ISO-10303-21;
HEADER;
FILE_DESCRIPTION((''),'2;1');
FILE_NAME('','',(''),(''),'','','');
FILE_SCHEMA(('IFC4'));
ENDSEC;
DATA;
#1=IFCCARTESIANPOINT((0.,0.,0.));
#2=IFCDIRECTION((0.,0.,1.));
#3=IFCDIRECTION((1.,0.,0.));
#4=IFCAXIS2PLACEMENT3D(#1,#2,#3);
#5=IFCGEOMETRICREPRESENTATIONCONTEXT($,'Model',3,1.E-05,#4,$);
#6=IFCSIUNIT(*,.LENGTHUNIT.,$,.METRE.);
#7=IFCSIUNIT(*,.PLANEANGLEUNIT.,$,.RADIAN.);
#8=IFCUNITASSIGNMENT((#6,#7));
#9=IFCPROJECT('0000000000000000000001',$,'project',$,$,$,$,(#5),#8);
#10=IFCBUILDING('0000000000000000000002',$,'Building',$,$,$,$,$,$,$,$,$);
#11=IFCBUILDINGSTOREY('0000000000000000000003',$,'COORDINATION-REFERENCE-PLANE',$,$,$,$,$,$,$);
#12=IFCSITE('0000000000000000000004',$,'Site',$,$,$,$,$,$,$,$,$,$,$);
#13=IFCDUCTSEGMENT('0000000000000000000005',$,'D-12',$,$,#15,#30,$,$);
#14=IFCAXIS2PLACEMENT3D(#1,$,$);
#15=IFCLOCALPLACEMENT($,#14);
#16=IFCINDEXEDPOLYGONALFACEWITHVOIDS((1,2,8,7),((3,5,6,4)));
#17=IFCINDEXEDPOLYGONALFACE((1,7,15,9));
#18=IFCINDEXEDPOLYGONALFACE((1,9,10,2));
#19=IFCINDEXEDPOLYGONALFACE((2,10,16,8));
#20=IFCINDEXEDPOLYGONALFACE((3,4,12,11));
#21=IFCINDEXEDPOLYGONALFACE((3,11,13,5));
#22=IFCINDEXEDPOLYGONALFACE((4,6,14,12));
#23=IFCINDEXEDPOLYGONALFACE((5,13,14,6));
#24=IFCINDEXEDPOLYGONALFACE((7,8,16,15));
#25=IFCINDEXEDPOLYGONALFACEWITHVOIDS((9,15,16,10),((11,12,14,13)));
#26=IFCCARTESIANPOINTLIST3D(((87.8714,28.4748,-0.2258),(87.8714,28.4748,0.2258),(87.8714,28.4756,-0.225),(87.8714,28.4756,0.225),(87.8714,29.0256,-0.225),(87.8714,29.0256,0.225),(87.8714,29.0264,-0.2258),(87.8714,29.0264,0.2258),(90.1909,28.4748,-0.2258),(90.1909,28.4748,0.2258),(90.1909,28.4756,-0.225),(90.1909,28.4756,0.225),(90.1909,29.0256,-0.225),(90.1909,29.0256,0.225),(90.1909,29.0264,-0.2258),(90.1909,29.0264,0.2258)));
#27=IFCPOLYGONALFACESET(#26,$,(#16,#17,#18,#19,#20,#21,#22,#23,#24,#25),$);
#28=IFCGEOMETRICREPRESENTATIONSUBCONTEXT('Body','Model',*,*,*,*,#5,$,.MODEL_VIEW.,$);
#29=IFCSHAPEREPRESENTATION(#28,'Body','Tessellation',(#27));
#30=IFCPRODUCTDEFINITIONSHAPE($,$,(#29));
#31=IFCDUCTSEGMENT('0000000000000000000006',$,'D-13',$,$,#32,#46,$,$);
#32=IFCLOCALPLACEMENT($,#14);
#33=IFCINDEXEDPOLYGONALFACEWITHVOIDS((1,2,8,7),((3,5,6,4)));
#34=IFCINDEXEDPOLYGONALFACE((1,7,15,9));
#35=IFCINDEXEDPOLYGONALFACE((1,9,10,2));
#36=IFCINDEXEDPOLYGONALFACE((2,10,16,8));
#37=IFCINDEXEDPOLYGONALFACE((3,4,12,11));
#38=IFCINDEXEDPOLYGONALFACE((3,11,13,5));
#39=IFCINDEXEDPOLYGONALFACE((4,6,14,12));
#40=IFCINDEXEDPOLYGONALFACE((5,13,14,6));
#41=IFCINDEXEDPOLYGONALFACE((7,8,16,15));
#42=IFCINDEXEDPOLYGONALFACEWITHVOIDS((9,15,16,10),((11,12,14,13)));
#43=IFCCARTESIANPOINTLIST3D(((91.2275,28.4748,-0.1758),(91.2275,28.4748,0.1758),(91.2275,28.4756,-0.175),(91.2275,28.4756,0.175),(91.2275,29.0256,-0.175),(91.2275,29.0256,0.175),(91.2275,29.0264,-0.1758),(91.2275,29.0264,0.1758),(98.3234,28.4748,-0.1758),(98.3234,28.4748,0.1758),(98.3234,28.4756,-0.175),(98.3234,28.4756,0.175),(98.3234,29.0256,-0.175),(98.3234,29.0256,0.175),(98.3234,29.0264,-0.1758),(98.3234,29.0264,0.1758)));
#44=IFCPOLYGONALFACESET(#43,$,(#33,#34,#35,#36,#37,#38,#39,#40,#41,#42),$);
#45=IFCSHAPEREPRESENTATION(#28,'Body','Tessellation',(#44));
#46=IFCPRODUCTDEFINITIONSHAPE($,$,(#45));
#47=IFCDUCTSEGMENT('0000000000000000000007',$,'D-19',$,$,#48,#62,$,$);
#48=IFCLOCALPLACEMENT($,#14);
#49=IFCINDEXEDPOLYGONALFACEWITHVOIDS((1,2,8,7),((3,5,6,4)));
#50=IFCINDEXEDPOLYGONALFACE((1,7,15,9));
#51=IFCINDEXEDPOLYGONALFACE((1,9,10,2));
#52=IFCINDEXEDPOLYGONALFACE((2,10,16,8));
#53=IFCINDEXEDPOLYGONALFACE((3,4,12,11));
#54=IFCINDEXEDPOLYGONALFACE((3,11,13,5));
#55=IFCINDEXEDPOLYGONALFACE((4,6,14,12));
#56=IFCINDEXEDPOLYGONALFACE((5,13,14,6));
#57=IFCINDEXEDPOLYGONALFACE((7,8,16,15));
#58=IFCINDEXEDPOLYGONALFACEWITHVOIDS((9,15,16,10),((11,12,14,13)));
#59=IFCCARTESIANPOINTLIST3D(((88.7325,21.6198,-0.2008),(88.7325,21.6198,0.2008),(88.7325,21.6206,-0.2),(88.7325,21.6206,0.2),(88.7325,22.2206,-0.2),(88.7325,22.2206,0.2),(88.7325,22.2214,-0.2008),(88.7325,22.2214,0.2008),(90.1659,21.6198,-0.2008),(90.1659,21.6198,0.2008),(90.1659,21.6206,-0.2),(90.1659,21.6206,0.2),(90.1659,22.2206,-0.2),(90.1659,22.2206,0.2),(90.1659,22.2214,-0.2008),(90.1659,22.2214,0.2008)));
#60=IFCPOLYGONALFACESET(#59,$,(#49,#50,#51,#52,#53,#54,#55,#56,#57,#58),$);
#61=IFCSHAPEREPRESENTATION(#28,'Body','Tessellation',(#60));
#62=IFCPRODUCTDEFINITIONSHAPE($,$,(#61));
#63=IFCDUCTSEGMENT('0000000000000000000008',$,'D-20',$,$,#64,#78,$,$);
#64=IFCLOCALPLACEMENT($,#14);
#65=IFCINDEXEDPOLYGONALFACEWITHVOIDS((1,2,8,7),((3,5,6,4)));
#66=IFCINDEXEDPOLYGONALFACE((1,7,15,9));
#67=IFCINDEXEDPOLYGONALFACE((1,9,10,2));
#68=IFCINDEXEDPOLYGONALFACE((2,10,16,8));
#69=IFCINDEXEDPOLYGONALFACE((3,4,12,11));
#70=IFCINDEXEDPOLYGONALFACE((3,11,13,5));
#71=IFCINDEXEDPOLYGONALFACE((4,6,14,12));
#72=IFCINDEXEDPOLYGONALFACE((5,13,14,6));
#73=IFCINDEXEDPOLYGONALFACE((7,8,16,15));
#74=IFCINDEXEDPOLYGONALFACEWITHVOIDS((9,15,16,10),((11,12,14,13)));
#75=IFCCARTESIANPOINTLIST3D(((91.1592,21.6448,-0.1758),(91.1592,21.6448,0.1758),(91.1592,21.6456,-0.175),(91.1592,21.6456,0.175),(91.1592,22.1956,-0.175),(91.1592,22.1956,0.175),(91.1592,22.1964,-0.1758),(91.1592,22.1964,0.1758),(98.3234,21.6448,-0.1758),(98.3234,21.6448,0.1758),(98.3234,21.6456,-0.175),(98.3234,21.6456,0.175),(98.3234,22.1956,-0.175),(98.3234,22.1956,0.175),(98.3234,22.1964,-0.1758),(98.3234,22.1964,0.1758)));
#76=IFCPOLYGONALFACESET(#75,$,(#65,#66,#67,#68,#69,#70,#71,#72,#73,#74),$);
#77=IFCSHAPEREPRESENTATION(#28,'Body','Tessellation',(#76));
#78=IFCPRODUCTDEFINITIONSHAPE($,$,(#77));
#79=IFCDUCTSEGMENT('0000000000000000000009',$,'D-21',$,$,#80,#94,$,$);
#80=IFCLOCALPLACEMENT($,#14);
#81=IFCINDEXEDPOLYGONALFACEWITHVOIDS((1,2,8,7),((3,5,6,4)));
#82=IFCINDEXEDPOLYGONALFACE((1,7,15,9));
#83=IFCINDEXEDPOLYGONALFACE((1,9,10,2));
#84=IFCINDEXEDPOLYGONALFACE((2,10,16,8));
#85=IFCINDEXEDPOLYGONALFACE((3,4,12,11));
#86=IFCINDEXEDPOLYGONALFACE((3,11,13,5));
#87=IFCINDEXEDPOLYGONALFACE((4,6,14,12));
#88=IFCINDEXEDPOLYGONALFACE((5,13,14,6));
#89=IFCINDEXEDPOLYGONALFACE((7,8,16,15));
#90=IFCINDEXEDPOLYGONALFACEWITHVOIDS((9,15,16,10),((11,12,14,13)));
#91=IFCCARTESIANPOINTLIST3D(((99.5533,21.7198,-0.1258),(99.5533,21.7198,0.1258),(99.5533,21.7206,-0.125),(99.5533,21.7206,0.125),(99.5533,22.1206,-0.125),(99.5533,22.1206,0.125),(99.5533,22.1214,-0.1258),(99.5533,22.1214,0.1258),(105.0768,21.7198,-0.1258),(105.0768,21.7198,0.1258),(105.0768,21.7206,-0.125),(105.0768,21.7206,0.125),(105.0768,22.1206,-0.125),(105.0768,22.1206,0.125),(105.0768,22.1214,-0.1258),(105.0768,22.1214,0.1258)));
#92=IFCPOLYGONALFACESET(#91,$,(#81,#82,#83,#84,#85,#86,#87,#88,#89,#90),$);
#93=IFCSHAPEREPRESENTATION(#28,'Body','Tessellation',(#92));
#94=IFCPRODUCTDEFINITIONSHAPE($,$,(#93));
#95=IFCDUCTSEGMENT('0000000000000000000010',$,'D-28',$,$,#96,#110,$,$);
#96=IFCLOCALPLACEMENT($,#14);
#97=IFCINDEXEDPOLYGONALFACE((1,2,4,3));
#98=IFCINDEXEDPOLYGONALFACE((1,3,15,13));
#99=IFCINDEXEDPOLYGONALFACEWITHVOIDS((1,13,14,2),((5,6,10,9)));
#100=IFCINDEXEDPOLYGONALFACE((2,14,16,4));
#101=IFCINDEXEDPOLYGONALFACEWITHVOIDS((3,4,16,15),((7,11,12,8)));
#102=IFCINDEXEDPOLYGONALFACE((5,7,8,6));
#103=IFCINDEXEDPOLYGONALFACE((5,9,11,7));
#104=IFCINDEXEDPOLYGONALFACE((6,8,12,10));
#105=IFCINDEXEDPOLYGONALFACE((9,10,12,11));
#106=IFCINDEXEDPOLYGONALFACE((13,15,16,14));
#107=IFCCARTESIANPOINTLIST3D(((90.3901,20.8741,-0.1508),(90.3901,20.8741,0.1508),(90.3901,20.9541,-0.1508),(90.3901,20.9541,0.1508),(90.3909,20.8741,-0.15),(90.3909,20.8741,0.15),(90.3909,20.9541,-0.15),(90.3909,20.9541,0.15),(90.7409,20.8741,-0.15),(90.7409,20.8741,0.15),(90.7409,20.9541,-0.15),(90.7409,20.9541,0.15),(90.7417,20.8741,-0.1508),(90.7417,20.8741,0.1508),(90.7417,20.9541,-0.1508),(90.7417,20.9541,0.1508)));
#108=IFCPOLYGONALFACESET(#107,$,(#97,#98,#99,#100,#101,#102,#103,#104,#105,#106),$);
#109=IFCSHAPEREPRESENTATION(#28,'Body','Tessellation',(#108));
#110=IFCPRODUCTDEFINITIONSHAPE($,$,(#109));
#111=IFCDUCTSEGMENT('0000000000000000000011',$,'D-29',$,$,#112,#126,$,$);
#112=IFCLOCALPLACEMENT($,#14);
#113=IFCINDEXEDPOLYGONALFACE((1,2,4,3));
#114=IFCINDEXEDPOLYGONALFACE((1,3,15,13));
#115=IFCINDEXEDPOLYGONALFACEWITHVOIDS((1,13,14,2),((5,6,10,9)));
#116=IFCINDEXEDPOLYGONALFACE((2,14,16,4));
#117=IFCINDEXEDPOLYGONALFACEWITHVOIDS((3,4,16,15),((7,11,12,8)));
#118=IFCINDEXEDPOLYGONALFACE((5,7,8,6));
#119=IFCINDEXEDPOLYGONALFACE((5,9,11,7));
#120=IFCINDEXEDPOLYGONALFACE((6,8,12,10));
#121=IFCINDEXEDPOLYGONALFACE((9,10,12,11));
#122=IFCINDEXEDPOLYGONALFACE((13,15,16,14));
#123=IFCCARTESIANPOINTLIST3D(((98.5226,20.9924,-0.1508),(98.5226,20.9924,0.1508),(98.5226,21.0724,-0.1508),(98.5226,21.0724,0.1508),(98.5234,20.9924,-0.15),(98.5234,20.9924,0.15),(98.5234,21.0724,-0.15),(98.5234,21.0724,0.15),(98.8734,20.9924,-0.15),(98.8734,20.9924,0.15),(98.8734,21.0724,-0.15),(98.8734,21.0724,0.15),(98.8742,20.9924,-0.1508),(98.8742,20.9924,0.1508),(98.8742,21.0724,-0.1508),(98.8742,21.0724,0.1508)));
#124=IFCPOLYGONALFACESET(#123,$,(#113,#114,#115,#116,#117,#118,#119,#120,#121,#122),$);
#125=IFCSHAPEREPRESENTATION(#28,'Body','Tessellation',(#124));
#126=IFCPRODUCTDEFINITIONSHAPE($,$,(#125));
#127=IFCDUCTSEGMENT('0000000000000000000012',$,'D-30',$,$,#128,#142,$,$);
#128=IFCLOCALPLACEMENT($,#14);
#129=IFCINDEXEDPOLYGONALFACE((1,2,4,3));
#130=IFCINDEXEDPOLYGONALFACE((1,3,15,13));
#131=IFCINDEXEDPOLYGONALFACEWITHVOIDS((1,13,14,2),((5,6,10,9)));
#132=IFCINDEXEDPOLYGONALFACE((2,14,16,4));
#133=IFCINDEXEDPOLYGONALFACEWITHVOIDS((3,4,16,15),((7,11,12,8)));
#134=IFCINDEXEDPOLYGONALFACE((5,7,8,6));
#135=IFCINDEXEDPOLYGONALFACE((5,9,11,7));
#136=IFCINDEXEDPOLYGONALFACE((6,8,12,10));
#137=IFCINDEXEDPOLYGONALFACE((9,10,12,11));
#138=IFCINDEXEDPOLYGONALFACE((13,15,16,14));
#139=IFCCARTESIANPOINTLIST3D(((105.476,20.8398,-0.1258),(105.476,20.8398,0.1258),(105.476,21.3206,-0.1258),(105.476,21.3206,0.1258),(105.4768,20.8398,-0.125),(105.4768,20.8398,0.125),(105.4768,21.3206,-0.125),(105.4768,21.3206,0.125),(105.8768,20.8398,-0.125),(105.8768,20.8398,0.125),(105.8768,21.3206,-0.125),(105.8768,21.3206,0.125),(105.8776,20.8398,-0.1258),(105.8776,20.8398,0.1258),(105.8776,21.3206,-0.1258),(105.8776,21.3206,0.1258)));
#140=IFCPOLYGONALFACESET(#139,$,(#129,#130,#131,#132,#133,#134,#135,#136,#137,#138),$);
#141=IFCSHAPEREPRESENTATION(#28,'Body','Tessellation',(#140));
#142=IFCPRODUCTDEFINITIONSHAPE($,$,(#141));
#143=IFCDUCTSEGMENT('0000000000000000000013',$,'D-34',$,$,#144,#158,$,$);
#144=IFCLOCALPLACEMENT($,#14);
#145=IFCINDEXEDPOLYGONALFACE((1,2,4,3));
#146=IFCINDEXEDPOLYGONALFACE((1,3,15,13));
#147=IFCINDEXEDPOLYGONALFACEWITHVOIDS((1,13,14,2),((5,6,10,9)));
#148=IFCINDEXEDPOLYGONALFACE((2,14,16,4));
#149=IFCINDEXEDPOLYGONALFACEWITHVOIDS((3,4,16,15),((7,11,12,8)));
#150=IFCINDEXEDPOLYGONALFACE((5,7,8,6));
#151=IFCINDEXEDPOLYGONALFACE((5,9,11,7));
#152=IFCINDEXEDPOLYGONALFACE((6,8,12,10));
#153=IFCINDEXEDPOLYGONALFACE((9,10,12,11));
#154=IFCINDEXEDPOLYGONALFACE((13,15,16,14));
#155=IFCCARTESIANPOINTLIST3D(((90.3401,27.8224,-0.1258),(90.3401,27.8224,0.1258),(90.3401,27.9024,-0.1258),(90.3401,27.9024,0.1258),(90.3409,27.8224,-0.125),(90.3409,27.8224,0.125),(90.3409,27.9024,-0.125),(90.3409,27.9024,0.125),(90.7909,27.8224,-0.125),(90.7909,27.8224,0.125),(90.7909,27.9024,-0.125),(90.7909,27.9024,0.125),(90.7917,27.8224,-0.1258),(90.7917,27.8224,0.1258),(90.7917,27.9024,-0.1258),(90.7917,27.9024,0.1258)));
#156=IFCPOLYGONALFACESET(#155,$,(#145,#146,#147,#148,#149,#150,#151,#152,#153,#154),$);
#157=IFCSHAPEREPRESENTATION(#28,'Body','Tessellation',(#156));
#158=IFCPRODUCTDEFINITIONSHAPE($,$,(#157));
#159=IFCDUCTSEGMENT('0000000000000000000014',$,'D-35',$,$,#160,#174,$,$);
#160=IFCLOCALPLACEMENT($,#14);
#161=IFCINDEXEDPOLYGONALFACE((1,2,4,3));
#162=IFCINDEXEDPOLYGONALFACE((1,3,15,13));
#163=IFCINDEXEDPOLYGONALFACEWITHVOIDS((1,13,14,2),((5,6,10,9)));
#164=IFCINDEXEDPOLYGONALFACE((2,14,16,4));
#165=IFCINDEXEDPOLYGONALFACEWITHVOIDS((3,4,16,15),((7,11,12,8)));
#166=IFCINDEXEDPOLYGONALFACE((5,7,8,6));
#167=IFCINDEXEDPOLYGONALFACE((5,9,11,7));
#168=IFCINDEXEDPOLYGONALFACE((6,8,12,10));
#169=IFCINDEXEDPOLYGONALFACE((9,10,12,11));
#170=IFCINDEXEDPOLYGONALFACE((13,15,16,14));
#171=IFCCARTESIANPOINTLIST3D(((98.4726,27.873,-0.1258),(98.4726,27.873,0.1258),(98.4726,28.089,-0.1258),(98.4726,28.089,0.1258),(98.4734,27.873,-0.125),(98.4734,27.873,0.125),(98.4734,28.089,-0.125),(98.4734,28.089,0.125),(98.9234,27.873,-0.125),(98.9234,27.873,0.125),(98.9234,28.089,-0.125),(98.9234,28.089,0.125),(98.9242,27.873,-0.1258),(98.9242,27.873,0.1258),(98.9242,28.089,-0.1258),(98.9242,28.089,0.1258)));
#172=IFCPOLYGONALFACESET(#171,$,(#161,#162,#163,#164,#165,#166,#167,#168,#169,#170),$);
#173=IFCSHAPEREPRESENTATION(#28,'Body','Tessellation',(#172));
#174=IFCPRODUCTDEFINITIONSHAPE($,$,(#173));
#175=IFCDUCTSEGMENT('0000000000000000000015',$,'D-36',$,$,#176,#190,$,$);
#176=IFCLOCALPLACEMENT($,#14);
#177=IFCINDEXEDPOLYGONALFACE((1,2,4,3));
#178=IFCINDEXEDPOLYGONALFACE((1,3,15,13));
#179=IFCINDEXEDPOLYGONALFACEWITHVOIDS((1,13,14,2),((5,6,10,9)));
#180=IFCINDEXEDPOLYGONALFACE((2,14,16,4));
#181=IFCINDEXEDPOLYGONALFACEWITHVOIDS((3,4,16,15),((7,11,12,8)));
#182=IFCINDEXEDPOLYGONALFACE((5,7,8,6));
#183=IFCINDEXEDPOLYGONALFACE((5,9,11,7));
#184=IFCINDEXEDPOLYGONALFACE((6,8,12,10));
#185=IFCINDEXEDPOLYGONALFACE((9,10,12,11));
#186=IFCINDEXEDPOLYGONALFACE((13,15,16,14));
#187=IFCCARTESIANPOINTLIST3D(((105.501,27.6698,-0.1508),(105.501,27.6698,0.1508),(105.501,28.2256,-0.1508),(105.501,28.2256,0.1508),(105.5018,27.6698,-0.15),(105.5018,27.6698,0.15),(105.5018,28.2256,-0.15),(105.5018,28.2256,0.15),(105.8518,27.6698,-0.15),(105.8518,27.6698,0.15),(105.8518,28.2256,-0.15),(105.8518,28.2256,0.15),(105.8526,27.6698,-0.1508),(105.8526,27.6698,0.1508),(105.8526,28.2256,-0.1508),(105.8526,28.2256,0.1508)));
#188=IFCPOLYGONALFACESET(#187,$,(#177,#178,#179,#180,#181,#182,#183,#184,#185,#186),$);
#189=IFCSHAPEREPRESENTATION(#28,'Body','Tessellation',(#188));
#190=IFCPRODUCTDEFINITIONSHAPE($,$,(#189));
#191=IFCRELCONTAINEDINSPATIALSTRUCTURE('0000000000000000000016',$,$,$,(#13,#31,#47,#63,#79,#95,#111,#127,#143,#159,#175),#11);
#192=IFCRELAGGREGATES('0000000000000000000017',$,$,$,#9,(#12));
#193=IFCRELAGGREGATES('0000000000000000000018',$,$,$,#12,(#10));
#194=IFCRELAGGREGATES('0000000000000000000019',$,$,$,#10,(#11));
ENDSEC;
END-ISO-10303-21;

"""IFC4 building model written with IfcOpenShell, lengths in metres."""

from ifc_helpers import new_model, si_unit, frame, origin, origin_with_axes, place, context, subcontext, project, spatial, hollow_rectangle, extrude, element, save


model = new_model("IFC4")

# Units and contexts
model_context = context("Model", 3, precision=1e-05, world=origin_with_axes())
body_context_1 = subcontext(model_context, "Body", "Model", "MODEL_VIEW")
ifc_project = project(units=[si_unit("LENGTHUNIT", "METRE"), si_unit("PLANEANGLEUNIT", "RADIAN")], contexts=[model_context])

# Site, building, storey
site = spatial("IfcSite", under=ifc_project, Name="Site")
building = spatial("IfcBuilding", under=site, Name="Building")
storey = spatial("IfcBuildingStorey", under=building, Name="COORDINATION-REFERENCE-PLANE")

# Duct segments
duct_segment_1_placement = place(None, frame((87.8714, 28.7506, 0.0), z_axis=(1.0, 0.0, 0.0), x_axis=(0.0, 1.0, 0.0)))
element("IfcDuctSegment", 1, at=duct_segment_1_placement, inside=storey, Name="D-12", context=body_context_1, shape_type="SweptSolid", body=[
    extrude(hollow_rectangle(XDim=0.5516, YDim=0.4516, WallThickness=0.0008), origin(), (0.0, 0.0, 1.0), 2.3195),
])
duct_segment_2_placement = place(None, frame((91.2275, 28.7506, 0.0), z_axis=(1.0, 0.0, 0.0), x_axis=(0.0, 1.0, 0.0)))
element("IfcDuctSegment", 2, at=duct_segment_2_placement, inside=storey, Name="D-13", context=body_context_1, shape_type="SweptSolid", body=[
    extrude(hollow_rectangle(XDim=0.5516, YDim=0.3516, WallThickness=0.0008), origin(), (0.0, 0.0, 1.0), 7.0959),
])
duct_segment_3_placement = place(None, frame((88.7325, 21.9206, 0.0), z_axis=(1.0, 0.0, 0.0), x_axis=(0.0, 1.0, 0.0)))
element("IfcDuctSegment", 3, at=duct_segment_3_placement, inside=storey, Name="D-19", context=body_context_1, shape_type="SweptSolid", body=[
    extrude(hollow_rectangle(XDim=0.6016, YDim=0.4016, WallThickness=0.0008), origin(), (0.0, 0.0, 1.0), 1.4334),
])
duct_segment_4_placement = place(None, frame((91.1592, 21.9206, 0.0), z_axis=(1.0, 0.0, 0.0), x_axis=(0.0, 1.0, 0.0)))
element("IfcDuctSegment", 4, at=duct_segment_4_placement, inside=storey, Name="D-20", context=body_context_1, shape_type="SweptSolid", body=[
    extrude(hollow_rectangle(XDim=0.5516, YDim=0.3516, WallThickness=0.0008), origin(), (0.0, 0.0, 1.0), 7.1642),
])
duct_segment_5_placement = place(None, frame((99.5533, 21.9206, 0.0), z_axis=(1.0, 0.0, 0.0), x_axis=(0.0, 1.0, 0.0)))
element("IfcDuctSegment", 5, at=duct_segment_5_placement, inside=storey, Name="D-21", context=body_context_1, shape_type="SweptSolid", body=[
    extrude(hollow_rectangle(XDim=0.4016, YDim=0.2516, WallThickness=0.0008), origin(), (0.0, 0.0, 1.0), 5.5234),
])
for number, where, z_axis, x_axis, name in (
    (6, (90.5659, 20.8741, 0.0), (0.0, 1.0, 0.0), (1.0, 0.0, 0.0), "D-28"),
    (7, (98.6984, 20.9924, 0.0), (0.0, 1.0, 0.0), (1.0, 0.0, 0.0), "D-29"),
):
    element("IfcDuctSegment", number, at=place(None, frame(where, z_axis=z_axis, x_axis=x_axis)), inside=storey, Name=name, context=body_context_1, shape_type="SweptSolid", body=[
        extrude(hollow_rectangle(XDim=0.3516, YDim=0.3016, WallThickness=0.0008), origin(), (0.0, 0.0, 1.0), 0.08),
    ])
duct_segment_6_placement = place(None, frame((105.6768, 20.8398, 0.0), z_axis=(0.0, 1.0, 0.0), x_axis=(1.0, 0.0, 0.0)))
element("IfcDuctSegment", 8, at=duct_segment_6_placement, inside=storey, Name="D-30", context=body_context_1, shape_type="SweptSolid", body=[
    extrude(hollow_rectangle(XDim=0.4016, YDim=0.2516, WallThickness=0.0008), origin(), (0.0, 0.0, 1.0), 0.4808),
])
duct_segment_7_placement = place(None, frame((90.5659, 27.8224, 0.0), z_axis=(0.0, 1.0, 0.0), x_axis=(1.0, 0.0, 0.0)))
element("IfcDuctSegment", 9, at=duct_segment_7_placement, inside=storey, Name="D-34", context=body_context_1, shape_type="SweptSolid", body=[
    extrude(hollow_rectangle(XDim=0.4516, YDim=0.2516, WallThickness=0.0008), origin(), (0.0, 0.0, 1.0), 0.08),
])
duct_segment_8_placement = place(None, frame((98.6984, 27.873, 0.0), z_axis=(0.0, 1.0, 0.0), x_axis=(1.0, 0.0, 0.0)))
element("IfcDuctSegment", 10, at=duct_segment_8_placement, inside=storey, Name="D-35", context=body_context_1, shape_type="SweptSolid", body=[
    extrude(hollow_rectangle(XDim=0.4516, YDim=0.2516, WallThickness=0.0008), origin(), (0.0, 0.0, 1.0), 0.216),
])
duct_segment_9_placement = place(None, frame((105.6768, 27.6698, 0.0), z_axis=(0.0, 1.0, 0.0), x_axis=(1.0, 0.0, 0.0)))
element("IfcDuctSegment", 11, at=duct_segment_9_placement, inside=storey, Name="D-36", context=body_context_1, shape_type="SweptSolid", body=[
    extrude(hollow_rectangle(XDim=0.3516, YDim=0.3016, WallThickness=0.0008), origin(), (0.0, 0.0, 1.0), 0.5558),
])

save(model, "model.ifc")
